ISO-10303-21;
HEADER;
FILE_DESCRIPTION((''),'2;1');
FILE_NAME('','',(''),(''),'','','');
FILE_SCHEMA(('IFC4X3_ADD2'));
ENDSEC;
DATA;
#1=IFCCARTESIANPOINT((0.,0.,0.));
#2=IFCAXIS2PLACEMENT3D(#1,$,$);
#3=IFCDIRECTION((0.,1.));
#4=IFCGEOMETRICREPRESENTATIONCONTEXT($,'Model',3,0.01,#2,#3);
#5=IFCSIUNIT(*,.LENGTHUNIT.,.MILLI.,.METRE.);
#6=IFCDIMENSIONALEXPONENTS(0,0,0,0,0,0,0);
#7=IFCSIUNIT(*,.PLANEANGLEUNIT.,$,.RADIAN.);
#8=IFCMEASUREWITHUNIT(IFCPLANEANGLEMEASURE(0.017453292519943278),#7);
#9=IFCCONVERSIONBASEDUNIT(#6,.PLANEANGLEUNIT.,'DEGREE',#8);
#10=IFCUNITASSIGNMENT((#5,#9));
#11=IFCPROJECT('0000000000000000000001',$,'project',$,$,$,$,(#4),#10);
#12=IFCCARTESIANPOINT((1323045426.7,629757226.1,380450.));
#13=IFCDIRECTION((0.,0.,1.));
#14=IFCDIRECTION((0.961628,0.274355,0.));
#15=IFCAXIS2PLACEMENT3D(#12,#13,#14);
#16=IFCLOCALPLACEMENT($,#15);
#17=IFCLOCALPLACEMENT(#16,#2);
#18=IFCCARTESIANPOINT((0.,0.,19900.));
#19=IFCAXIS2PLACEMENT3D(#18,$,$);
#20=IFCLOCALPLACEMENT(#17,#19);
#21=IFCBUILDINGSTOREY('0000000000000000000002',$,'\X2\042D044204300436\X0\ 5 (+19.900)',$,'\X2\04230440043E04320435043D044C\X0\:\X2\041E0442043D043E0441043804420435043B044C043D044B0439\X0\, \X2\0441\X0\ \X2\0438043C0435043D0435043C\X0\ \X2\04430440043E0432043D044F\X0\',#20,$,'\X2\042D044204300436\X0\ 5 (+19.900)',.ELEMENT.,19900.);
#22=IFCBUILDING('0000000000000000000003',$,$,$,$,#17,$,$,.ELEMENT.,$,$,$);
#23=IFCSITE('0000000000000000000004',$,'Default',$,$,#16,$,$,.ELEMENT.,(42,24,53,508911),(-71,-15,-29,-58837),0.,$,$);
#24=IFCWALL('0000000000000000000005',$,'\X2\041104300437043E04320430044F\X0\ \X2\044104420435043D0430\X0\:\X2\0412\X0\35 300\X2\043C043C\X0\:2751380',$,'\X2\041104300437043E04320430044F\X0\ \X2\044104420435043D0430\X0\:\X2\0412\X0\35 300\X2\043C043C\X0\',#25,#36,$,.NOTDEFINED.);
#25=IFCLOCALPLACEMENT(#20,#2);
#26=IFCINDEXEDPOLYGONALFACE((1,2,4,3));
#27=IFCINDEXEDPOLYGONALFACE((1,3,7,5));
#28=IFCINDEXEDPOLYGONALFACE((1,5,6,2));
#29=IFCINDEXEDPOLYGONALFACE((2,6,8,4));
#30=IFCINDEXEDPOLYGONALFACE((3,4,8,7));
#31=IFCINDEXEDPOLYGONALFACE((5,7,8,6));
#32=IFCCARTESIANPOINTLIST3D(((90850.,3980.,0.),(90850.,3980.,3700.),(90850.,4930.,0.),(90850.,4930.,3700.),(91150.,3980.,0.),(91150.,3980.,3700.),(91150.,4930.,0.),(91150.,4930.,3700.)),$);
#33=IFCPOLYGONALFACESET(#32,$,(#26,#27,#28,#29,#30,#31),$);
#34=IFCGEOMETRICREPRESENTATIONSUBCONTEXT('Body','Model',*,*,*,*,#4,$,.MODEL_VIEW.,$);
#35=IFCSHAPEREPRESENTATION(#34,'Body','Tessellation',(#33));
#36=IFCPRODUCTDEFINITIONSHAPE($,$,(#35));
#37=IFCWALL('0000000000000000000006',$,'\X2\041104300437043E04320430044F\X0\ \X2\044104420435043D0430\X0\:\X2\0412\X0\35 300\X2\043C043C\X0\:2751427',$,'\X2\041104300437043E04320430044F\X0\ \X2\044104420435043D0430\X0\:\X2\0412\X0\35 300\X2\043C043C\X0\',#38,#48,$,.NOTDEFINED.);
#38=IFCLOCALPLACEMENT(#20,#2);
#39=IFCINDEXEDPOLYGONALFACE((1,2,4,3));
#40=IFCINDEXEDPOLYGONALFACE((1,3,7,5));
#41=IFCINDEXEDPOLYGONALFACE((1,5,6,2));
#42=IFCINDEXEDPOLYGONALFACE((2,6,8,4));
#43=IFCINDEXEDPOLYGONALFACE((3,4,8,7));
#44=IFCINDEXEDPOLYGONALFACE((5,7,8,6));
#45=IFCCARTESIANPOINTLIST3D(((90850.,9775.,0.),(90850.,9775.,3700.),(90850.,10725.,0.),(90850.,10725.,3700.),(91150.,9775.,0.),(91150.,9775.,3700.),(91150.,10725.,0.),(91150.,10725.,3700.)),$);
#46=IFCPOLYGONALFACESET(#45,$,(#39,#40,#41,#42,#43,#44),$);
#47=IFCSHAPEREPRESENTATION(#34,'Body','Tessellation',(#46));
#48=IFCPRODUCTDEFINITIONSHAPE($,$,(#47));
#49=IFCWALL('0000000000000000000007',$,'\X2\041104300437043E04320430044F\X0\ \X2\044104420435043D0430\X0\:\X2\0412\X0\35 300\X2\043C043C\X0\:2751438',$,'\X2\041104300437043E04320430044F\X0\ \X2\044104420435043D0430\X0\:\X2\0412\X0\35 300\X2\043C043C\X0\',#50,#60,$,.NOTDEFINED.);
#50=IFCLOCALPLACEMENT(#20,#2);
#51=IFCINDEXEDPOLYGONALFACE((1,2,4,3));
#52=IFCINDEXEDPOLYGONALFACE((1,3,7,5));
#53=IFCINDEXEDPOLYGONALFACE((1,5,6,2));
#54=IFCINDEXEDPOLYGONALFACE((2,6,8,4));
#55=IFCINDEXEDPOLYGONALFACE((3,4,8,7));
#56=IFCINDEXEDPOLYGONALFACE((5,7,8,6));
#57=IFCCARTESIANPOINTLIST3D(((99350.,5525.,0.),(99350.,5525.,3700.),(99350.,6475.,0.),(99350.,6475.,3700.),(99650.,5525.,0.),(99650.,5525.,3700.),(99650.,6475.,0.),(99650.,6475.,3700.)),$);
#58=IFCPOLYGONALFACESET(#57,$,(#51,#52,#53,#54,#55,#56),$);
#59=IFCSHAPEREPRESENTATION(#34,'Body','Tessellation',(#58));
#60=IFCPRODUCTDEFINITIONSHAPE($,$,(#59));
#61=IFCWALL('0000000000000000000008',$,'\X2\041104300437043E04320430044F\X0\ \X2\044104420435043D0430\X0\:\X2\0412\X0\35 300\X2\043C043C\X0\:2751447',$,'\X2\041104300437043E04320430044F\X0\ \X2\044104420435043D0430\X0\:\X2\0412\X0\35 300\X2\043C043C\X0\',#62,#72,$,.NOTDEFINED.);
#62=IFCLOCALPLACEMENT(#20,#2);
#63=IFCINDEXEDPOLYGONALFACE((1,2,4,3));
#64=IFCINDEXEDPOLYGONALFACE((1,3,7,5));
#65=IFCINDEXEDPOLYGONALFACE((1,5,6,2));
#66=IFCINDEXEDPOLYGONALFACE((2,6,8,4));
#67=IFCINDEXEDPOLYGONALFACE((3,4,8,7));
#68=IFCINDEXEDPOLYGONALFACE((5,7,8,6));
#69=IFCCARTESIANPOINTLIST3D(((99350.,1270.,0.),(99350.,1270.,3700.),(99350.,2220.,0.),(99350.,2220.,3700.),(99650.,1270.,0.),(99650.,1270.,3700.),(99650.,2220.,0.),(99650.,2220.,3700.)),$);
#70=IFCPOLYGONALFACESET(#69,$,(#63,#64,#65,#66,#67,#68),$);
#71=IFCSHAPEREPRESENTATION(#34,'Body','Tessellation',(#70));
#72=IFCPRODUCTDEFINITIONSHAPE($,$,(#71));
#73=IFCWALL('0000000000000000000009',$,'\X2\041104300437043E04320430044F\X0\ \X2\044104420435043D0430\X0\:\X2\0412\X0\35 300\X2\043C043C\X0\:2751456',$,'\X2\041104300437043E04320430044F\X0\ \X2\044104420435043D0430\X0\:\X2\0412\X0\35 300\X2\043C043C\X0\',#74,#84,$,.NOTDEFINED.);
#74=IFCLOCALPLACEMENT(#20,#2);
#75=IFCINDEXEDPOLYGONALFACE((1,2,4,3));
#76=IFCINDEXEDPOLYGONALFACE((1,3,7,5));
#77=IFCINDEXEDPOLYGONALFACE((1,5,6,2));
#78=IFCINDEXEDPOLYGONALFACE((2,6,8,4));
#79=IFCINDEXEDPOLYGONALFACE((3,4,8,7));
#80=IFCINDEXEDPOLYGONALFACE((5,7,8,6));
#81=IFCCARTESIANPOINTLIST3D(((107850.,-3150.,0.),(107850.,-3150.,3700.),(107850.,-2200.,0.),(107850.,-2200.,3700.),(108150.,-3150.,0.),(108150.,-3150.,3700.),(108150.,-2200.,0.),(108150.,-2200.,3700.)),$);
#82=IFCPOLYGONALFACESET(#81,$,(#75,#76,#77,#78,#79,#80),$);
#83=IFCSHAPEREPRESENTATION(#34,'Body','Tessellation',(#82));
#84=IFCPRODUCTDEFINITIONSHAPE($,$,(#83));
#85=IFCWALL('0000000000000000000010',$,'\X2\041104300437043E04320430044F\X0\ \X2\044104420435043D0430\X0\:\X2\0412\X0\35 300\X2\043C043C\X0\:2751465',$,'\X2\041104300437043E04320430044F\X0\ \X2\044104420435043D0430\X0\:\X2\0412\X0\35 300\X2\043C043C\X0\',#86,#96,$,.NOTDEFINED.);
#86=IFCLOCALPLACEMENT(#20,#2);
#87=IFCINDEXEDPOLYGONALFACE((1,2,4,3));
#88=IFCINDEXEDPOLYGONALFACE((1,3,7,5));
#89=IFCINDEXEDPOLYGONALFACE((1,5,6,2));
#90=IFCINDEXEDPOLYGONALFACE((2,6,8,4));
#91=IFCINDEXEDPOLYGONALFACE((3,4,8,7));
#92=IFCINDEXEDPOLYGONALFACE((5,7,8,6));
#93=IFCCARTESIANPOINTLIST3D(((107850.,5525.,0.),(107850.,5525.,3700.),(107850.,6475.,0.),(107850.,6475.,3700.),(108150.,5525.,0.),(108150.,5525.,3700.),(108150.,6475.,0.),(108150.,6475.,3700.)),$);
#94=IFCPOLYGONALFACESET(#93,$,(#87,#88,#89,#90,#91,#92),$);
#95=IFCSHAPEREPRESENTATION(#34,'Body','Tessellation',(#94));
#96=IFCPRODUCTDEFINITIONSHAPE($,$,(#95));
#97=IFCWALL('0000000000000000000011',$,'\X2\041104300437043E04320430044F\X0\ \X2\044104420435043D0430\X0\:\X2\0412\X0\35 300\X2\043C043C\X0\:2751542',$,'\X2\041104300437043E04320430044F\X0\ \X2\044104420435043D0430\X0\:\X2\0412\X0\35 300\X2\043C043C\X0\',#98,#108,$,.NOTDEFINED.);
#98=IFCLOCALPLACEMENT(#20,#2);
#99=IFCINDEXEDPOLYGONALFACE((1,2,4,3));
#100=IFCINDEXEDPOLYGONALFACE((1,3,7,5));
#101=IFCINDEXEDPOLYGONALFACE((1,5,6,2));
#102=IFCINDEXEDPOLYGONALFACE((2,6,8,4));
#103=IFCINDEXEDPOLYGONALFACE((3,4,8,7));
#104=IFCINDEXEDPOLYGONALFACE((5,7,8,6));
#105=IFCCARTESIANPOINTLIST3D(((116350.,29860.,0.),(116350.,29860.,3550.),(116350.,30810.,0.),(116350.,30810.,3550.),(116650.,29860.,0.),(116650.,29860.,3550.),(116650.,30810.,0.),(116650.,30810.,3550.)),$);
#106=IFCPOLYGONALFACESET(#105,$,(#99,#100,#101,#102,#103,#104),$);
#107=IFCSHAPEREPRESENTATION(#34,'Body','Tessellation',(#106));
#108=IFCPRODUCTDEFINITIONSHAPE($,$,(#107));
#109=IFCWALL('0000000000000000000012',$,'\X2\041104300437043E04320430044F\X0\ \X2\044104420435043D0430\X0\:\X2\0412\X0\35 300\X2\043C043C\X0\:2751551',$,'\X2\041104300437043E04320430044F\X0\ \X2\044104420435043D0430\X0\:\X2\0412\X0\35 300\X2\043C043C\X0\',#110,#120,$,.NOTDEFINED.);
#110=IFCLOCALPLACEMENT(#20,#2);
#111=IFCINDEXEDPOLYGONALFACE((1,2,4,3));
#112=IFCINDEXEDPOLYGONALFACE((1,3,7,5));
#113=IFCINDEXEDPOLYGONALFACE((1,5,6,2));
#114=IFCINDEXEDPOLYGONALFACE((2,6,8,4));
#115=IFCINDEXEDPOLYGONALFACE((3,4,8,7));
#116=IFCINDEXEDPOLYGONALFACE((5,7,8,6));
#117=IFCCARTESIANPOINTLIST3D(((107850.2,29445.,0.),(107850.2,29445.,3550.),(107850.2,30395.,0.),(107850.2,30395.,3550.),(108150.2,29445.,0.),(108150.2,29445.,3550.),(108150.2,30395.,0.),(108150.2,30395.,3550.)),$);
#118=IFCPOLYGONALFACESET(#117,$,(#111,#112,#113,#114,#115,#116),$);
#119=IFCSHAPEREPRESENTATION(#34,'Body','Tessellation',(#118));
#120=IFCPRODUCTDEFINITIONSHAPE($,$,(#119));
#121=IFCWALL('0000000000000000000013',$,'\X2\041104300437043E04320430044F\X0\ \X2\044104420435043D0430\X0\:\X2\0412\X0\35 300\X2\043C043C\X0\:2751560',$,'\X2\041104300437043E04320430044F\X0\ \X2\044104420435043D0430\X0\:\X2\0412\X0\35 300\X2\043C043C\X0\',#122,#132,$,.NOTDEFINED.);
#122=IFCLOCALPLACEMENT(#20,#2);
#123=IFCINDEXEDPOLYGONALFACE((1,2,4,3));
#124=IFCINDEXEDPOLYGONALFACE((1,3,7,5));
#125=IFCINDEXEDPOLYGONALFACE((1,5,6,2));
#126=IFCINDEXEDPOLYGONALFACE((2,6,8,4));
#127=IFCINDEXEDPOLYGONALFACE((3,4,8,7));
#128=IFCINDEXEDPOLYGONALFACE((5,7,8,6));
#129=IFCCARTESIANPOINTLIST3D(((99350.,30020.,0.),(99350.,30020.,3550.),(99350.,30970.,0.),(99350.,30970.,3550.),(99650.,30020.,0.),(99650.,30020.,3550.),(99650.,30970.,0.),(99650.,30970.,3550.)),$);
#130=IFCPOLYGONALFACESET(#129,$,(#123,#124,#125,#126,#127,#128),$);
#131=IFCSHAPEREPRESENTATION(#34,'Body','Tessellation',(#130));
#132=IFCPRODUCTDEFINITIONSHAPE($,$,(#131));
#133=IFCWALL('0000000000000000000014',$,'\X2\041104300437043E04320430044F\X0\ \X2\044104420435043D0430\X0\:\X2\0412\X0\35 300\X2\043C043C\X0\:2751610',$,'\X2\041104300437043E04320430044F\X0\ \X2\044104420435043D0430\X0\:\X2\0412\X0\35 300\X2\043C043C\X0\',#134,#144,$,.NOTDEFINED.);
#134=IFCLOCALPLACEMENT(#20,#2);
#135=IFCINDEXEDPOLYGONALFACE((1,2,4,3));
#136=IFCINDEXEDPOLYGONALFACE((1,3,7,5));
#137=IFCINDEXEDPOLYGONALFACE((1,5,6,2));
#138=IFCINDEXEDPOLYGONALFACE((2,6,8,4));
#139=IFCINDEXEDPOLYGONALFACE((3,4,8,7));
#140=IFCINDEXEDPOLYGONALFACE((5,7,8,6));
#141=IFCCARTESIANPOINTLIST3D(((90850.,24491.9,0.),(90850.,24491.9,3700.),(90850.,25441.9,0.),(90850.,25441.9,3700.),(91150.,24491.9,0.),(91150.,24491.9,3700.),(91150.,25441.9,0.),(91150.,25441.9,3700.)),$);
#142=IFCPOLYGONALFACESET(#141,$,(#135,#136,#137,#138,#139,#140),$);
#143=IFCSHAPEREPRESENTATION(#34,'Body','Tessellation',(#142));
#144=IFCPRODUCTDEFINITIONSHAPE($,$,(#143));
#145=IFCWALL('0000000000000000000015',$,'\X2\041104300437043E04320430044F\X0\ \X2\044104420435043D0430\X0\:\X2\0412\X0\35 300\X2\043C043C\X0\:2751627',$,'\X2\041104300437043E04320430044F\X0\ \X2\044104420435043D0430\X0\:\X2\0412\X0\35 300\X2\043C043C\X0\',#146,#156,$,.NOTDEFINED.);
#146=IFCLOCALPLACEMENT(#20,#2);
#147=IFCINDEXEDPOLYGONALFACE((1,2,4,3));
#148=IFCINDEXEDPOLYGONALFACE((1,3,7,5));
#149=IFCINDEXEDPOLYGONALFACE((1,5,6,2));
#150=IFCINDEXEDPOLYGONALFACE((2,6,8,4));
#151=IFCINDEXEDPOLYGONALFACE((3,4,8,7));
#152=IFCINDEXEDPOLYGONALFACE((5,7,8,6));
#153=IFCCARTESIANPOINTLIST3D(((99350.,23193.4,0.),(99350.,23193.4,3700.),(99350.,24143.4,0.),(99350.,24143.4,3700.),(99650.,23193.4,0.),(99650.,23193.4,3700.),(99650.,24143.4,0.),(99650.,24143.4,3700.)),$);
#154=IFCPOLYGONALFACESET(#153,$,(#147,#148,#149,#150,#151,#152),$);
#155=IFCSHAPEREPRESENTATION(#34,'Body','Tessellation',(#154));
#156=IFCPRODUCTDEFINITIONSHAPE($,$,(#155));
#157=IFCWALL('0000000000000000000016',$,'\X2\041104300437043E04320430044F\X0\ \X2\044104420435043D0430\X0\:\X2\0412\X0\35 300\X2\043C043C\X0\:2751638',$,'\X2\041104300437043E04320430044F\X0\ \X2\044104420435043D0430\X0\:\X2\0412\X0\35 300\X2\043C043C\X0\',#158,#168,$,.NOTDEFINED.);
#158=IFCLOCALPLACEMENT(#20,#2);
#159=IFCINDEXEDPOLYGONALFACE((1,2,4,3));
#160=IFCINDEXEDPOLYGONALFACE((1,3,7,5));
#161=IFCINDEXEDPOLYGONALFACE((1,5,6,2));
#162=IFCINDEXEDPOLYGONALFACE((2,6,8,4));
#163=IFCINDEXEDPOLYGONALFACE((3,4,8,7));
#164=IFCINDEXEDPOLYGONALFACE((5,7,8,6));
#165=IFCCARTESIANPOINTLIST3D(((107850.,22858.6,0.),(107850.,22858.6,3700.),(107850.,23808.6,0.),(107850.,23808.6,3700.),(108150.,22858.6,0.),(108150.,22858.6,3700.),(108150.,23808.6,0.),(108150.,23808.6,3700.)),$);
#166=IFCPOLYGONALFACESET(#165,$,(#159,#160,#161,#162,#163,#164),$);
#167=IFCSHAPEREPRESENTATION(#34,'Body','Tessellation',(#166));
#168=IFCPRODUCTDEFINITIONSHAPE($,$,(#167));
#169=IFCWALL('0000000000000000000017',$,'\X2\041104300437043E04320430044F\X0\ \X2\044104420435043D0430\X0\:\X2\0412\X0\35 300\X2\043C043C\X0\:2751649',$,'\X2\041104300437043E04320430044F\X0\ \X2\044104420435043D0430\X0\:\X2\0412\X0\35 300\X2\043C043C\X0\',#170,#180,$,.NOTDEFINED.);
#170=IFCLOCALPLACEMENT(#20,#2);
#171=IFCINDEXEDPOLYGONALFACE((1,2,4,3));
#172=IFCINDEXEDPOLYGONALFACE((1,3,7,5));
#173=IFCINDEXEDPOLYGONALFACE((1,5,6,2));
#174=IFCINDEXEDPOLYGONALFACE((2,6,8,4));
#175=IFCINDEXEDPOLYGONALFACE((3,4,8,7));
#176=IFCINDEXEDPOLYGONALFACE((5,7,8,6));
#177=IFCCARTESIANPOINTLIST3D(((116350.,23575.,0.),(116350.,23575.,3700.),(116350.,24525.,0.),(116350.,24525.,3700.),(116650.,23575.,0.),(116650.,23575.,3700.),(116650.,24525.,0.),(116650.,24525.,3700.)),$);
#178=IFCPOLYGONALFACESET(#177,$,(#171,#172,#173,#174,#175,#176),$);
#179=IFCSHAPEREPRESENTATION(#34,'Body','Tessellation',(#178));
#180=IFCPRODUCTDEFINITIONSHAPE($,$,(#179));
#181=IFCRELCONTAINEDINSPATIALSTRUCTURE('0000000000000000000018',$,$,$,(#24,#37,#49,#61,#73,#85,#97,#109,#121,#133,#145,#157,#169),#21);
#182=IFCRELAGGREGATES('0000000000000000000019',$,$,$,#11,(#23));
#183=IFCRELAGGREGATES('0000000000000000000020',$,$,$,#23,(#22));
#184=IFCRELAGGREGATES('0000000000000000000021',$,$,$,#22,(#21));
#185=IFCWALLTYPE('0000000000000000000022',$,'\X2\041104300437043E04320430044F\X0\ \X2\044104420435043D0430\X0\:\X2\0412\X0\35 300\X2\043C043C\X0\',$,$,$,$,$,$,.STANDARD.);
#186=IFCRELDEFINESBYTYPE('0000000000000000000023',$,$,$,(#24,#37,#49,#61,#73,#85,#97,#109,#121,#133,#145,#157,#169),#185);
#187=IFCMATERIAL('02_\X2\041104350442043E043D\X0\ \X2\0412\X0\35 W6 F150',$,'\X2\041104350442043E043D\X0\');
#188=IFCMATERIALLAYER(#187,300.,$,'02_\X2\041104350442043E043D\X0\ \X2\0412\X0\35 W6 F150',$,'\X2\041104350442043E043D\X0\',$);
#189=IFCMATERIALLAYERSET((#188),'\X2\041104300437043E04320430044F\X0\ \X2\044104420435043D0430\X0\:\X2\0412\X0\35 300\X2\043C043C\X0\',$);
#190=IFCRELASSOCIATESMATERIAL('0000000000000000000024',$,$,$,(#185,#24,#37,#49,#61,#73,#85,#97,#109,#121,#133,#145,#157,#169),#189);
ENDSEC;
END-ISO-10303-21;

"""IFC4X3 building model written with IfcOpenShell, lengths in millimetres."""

from ifc_helpers import new_model, entity, si_unit, converted_unit, direction, frame, frame_2d, origin, place, context, subcontext, project, spatial, rectangle, extrude, material, layer, layer_set, type_object, element, save


model = new_model("IFC4X3")

# Units and contexts
model_context = context("Model", 3, precision=0.01, world=origin(), true_north=direction((0.0, 1.0)))
body_context = subcontext(model_context, "Body", "Model", "MODEL_VIEW")
ifc_project = project(units=[si_unit("LENGTHUNIT", "METRE", prefix="MILLI"), converted_unit("PLANEANGLEUNIT", "DEGREE", entity("IfcPlaneAngleMeasure", 0.017453292519943278), si_unit("PLANEANGLEUNIT", "RADIAN"), dimensions=[0, 0, 0, 0, 0, 0, 0])], contexts=[model_context])

# Site, building, storey
site_placement = place(None, frame((1323045426.7, 629757226.1, 380450.0), z_axis=(0.0, 0.0, 1.0), x_axis=(0.961628, 0.274355, 0.0)))
site = spatial("IfcSite", under=ifc_project, at=site_placement, Name="Default", CompositionType="ELEMENT", RefLatitude=(42, 24, 53, 508911), RefLongitude=(-71, -15, -29, -58837), RefElevation=0.0)
building_placement = place(site_placement, origin())
building = spatial("IfcBuilding", under=site, at=building_placement, CompositionType="ELEMENT")
storey_placement = place(building_placement, frame((0.0, 0.0, 19900.0)))
storey = spatial("IfcBuildingStorey", under=building, at=storey_placement, Name="Этаж 5 (+19.900)", ObjectType="Уровень:Относительный, с именем уровня", LongName="Этаж 5 (+19.900)", CompositionType="ELEMENT", Elevation=19900.0)

# Walls
ifc_material = material(Name="02_Бетон В35 W6 F150", Category="Бетон")
ifc_layer_1 = layer(ifc_material, 300.0, Name="02_Бетон В35 W6 F150", Category="Бетон")
ifc_layer_set_1 = layer_set([ifc_layer_1], Name="Базовая стена:В35 300мм")
wall_type_1 = type_object("IfcWallType", Name="Базовая стена:В35 300мм", PredefinedType="STANDARD", material=ifc_layer_set_1)
for number, where, z_axis, x_axis, name in (
    (1, (91000.0, 3980.0, 0.0), (0.0, 0.0, 1.0), (0.0, 1.0, 0.0), "Базовая стена:В35 300мм:2751380"),
    (2, (91000.0, 9775.0, 0.0), (0.0, 0.0, 1.0), (0.0, 1.0, 0.0), "Базовая стена:В35 300мм:2751427"),
    (3, (99500.0, 5525.0, 0.0), (0.0, 0.0, 1.0), (0.0, 1.0, 0.0), "Базовая стена:В35 300мм:2751438"),
    (4, (99500.0, 1270.0, 0.0), (0.0, 0.0, 1.0), (0.0, 1.0, 0.0), "Базовая стена:В35 300мм:2751447"),
    (5, (108000.0, -3150.0, 0.0), (0.0, 0.0, 1.0), (0.0, 1.0, 0.0), "Базовая стена:В35 300мм:2751456"),
    (6, (108000.0, 5525.0, 0.0), (0.0, 0.0, 1.0), (0.0, 1.0, 0.0), "Базовая стена:В35 300мм:2751465"),
):
    element("IfcWall", number, at=place(storey_placement, frame(where, z_axis=z_axis, x_axis=x_axis)), inside=storey, type_object=wall_type_1, material=ifc_layer_set_1, Name=name, ObjectType="Базовая стена:В35 300мм", PredefinedType="NOTDEFINED", context=body_context, shape_type="SweptSolid", body=[
        extrude(rectangle(XDim=950.0, YDim=300.0, at=frame_2d((475.0, 0.0), x_axis=(-1.0, 0.0))), origin(), (0.0, 0.0, 1.0), 3700.0),
    ])
for number, where, z_axis, x_axis, name in (
    (7, (116500.0, 29860.0, 0.0), (0.0, 0.0, 1.0), (0.0, 1.0, 0.0), "Базовая стена:В35 300мм:2751542"),
    (8, (108000.2, 29445.0, 0.0), (0.0, 0.0, 1.0), (0.0, 1.0, 0.0), "Базовая стена:В35 300мм:2751551"),
    (9, (99500.0, 30020.0, 0.0), (0.0, 0.0, 1.0), (0.0, 1.0, 0.0), "Базовая стена:В35 300мм:2751560"),
):
    element("IfcWall", number, at=place(storey_placement, frame(where, z_axis=z_axis, x_axis=x_axis)), inside=storey, type_object=wall_type_1, material=ifc_layer_set_1, Name=name, ObjectType="Базовая стена:В35 300мм", PredefinedType="NOTDEFINED", context=body_context, shape_type="SweptSolid", body=[
        extrude(rectangle(XDim=950.0, YDim=300.0, at=frame_2d((475.0, 0.0), x_axis=(-1.0, 0.0))), origin(), (0.0, 0.0, 1.0), 3550.0),
    ])
wall_1_placement = place(storey_placement, frame((91000.0, 24491.9, 0.0), z_axis=(0.0, 0.0, 1.0), x_axis=(0.0, 1.0, 0.0)))
element("IfcWall", 10, at=wall_1_placement, inside=storey, type_object=wall_type_1, material=ifc_layer_set_1, Name="Базовая стена:В35 300мм:2751610", ObjectType="Базовая стена:В35 300мм", PredefinedType="NOTDEFINED", context=body_context, shape_type="SweptSolid", body=[
    extrude(rectangle(XDim=950.0, YDim=300.0, at=frame_2d((475.0, 0.0), x_axis=(-1.0, 0.0))), origin(), (0.0, 0.0, 1.0), 3700.0),
])
for number, where, z_axis, x_axis, name in (
    (11, (99500.0, 23193.4, 0.0), (0.0, 0.0, 1.0), (0.0, 1.0, 0.0), "Базовая стена:В35 300мм:2751627"),
    (12, (108000.0, 22858.6, 0.0), (0.0, 0.0, 1.0), (0.0, 1.0, 0.0), "Базовая стена:В35 300мм:2751638"),
    (13, (116500.0, 23575.0, 0.0), (0.0, 0.0, 1.0), (0.0, 1.0, 0.0), "Базовая стена:В35 300мм:2751649"),
):
    element("IfcWall", number, at=place(storey_placement, frame(where, z_axis=z_axis, x_axis=x_axis)), inside=storey, type_object=wall_type_1, material=ifc_layer_set_1, Name=name, ObjectType="Базовая стена:В35 300мм", PredefinedType="NOTDEFINED", context=body_context, shape_type="SweptSolid", body=[
        extrude(rectangle(XDim=950.0, YDim=300.0, at=frame_2d((475.0, 0.0), x_axis=(-1.0, 0.0))), origin(), (0.0, 0.0, 1.0), 3700.0),
    ])

save(model, "model.ifc")
